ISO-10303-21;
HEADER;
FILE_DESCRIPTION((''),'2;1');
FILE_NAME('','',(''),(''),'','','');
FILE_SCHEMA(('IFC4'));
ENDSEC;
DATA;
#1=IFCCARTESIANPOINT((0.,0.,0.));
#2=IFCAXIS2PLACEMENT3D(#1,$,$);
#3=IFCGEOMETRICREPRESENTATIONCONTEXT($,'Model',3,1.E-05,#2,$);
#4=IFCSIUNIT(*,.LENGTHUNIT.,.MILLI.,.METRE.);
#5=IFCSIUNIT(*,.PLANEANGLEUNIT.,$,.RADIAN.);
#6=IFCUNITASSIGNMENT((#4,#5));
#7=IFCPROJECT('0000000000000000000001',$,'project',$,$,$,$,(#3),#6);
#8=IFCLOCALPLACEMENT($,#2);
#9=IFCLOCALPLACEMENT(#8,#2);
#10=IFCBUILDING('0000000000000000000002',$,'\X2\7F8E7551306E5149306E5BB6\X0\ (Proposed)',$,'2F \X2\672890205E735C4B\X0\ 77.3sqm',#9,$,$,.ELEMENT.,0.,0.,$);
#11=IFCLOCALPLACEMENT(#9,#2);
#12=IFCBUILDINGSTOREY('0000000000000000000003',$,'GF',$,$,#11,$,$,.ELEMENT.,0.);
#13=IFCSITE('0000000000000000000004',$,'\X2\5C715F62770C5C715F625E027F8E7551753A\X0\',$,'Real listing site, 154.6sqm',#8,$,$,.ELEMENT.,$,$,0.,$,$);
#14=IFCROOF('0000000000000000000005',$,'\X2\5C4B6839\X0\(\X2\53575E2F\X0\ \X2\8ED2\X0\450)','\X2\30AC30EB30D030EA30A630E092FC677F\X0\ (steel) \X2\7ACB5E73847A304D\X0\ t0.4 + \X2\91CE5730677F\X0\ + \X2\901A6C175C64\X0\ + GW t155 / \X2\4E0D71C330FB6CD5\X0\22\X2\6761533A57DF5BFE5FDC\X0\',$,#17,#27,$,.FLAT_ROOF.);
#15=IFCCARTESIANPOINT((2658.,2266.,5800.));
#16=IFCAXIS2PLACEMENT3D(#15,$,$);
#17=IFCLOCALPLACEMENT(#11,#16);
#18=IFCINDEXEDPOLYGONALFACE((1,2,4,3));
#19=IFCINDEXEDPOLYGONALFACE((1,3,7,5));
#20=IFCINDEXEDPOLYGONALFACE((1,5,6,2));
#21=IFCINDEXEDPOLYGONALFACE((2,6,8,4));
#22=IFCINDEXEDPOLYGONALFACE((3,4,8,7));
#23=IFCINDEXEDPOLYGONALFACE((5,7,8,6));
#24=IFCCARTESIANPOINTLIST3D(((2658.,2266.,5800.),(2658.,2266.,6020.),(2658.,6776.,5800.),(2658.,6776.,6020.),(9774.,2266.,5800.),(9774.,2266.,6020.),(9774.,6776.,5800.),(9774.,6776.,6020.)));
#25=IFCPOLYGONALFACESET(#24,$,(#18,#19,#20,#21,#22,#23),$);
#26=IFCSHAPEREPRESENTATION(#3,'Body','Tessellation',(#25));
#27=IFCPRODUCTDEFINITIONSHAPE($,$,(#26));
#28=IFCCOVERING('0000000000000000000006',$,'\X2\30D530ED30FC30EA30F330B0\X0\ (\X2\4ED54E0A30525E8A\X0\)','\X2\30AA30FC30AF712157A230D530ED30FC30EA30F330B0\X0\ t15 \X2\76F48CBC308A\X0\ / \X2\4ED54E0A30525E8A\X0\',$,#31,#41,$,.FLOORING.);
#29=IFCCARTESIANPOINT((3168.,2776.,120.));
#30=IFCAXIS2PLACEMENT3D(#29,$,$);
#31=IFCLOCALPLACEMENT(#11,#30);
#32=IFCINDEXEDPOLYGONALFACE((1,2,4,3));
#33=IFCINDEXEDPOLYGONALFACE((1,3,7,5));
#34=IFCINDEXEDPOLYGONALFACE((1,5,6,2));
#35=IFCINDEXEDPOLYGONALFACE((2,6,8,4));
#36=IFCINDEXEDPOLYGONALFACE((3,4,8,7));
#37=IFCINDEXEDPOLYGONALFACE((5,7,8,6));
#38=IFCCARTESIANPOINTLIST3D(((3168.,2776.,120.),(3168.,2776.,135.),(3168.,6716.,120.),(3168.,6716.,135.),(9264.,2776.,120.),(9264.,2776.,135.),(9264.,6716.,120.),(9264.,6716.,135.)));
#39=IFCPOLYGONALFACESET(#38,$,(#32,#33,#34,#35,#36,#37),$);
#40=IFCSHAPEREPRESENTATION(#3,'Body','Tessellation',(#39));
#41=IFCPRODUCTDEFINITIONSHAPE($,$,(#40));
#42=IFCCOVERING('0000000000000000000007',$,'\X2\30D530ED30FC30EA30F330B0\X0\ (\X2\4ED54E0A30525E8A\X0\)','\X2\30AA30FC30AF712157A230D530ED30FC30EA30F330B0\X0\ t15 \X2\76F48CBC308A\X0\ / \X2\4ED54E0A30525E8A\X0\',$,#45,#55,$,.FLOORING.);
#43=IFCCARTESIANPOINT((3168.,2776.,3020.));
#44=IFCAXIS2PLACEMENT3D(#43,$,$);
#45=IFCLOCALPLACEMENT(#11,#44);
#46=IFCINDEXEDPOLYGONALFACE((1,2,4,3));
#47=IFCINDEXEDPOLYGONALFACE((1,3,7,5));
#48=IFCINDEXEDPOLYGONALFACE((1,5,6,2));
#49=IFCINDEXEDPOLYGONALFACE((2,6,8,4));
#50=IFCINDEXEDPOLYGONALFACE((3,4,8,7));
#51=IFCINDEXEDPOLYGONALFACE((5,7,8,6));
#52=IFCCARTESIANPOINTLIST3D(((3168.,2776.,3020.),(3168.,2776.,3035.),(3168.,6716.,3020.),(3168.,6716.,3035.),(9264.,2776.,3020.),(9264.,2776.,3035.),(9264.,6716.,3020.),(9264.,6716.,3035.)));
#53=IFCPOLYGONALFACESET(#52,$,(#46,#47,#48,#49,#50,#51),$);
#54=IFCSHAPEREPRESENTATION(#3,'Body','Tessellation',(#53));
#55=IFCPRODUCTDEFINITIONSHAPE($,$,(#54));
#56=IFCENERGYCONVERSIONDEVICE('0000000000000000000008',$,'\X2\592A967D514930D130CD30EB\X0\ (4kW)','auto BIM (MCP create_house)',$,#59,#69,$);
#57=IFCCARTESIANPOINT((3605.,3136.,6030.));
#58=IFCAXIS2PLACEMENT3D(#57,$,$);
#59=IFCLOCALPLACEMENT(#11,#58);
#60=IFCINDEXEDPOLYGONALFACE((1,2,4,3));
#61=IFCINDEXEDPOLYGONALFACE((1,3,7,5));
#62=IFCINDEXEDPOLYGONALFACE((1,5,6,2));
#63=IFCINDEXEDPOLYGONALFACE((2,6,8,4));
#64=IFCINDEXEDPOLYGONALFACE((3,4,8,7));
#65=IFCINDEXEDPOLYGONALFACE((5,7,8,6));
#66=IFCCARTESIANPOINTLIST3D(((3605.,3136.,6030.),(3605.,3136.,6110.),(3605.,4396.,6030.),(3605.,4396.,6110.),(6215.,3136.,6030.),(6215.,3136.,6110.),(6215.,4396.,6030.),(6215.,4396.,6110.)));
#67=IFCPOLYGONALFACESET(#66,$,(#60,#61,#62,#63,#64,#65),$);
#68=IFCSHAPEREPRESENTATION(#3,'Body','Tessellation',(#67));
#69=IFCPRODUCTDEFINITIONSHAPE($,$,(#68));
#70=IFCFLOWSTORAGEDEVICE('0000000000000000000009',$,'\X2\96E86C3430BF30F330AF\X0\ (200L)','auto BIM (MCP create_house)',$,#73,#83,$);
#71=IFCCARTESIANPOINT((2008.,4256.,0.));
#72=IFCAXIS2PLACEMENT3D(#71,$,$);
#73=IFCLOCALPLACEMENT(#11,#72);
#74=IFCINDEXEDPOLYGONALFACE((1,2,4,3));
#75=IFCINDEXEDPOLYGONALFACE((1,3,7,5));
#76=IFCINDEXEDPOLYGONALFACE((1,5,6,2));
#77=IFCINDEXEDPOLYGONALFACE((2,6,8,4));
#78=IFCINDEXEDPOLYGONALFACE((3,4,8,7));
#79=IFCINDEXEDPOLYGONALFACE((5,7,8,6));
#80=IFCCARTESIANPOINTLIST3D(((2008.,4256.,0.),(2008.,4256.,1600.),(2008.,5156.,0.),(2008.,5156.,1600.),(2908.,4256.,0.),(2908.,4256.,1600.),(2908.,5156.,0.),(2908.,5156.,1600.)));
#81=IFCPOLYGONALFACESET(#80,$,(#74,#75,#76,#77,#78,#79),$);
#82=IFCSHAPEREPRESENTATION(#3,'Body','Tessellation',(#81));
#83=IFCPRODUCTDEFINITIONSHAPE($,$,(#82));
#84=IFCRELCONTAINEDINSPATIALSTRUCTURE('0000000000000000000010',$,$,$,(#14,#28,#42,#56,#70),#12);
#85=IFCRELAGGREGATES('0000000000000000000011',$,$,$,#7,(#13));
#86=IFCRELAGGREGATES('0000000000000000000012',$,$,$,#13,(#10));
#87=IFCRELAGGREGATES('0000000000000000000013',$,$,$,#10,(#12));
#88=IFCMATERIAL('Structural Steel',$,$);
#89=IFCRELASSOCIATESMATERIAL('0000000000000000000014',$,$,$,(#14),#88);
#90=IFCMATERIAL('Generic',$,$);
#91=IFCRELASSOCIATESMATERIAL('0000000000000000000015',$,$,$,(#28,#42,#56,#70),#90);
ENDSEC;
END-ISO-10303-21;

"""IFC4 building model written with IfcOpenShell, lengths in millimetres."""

from ifc_helpers import new_model, si_unit, frame, frame_2d, origin, place, context, project, spatial, rectangle, extrude, material, element, save


model = new_model("IFC4")

# Units and contexts
model_context = context("Model", 3, precision=1e-05, world=origin())
ifc_project = project(units=[si_unit("LENGTHUNIT", "METRE", prefix="MILLI"), si_unit("PLANEANGLEUNIT", "RADIAN")], contexts=[model_context])

# Site, building, storey
site_placement = place(None, origin())
site = spatial("IfcSite", under=ifc_project, at=site_placement, Name="山形県山形市美畑町", ObjectType="Real listing site, 154.6sqm", CompositionType="ELEMENT", RefElevation=0.0)
building_placement = place(site_placement, origin())
building = spatial("IfcBuilding", under=site, at=building_placement, Name="美畑の光の家 (Proposed)", ObjectType="2F 木造平屋 77.3sqm", CompositionType="ELEMENT", ElevationOfRefHeight=0.0, ElevationOfTerrain=0.0)
storey_placement = place(building_placement, origin())
storey = spatial("IfcBuildingStorey", under=building, at=storey_placement, Name="GF", CompositionType="ELEMENT", Elevation=0.0)

# Roof
ifc_material_1 = material(Name="Structural Steel")
for number, where, name in (
    (1, (2658.0, 2266.0, 5800.0), "屋根(南帯 軒450)"),
):
    element("IfcRoof", number, at=place(storey_placement, frame(where)), inside=storey, material=ifc_material_1, Name=name, Description="ガルバリウム鋼板 (steel) 立平葺き t0.4 + 野地板 + 通気層 + GW t155 / 不燃・法22条区域対応", PredefinedType="FLAT_ROOF", context=model_context, shape_type="SweptSolid", body=[
        extrude(rectangle(XDim=7116.0, YDim=4510.0, at=frame_2d((3558.0, 2255.0))), frame((2658.0, 2266.0, 5800.0)), (0.0, 0.0, 1.0), 220.0),
    ])

# Coverings
ifc_material_2 = material(Name="Generic")
covering_1_placement = place(storey_placement, frame((3168.0, 2776.0, 120.0)))
element("IfcCovering", 2, at=covering_1_placement, inside=storey, material=ifc_material_2, Name="フローリング (仕上げ床)", Description="オーク無垢フローリング t15 直貼り / 仕上げ床", PredefinedType="FLOORING", context=model_context, shape_type="SweptSolid", body=[
    extrude(rectangle(XDim=6096.0, YDim=3940.0, at=frame_2d((3048.0, 1970.0))), frame((3168.0, 2776.0, 120.0)), (0.0, 0.0, 1.0), 15.0),
])
covering_2_placement = place(storey_placement, frame((3168.0, 2776.0, 3020.0)))
element("IfcCovering", 3, at=covering_2_placement, inside=storey, material=ifc_material_2, Name="フローリング (仕上げ床)", Description="オーク無垢フローリング t15 直貼り / 仕上げ床", PredefinedType="FLOORING", context=model_context, shape_type="SweptSolid", body=[
    extrude(rectangle(XDim=6096.0, YDim=3940.0, at=frame_2d((3048.0, 1970.0))), frame((3168.0, 2776.0, 3020.0)), (0.0, 0.0, 1.0), 15.0),
])

# Energy conversion device
energy_conversion_device_placement = place(storey_placement, frame((3605.0, 3136.0, 6030.0)))
element("IfcEnergyConversionDevice", 4, at=energy_conversion_device_placement, inside=storey, material=ifc_material_2, Name="太陽光パネル (4kW)", Description="auto BIM (MCP create_house)", context=model_context, shape_type="SweptSolid", body=[
    extrude(rectangle(XDim=2610.0, YDim=1260.0, at=frame_2d((1305.0, 630.0))), frame((3605.0, 3136.0, 6030.0)), (0.0, 0.0, 1.0), 80.0),
])

# Flow storage device
flow_storage_device_placement = place(storey_placement, frame((2008.0, 4256.0, 0.0)))
element("IfcFlowStorageDevice", 5, at=flow_storage_device_placement, inside=storey, material=ifc_material_2, Name="雨水タンク (200L)", Description="auto BIM (MCP create_house)", context=model_context, shape_type="SweptSolid", body=[
    extrude(rectangle(XDim=900.0, YDim=900.0, at=frame_2d((450.0, 450.0))), frame((2008.0, 4256.0, 0.0)), (0.0, 0.0, 1.0), 1600.0),
])

save(model, "model.ifc")
